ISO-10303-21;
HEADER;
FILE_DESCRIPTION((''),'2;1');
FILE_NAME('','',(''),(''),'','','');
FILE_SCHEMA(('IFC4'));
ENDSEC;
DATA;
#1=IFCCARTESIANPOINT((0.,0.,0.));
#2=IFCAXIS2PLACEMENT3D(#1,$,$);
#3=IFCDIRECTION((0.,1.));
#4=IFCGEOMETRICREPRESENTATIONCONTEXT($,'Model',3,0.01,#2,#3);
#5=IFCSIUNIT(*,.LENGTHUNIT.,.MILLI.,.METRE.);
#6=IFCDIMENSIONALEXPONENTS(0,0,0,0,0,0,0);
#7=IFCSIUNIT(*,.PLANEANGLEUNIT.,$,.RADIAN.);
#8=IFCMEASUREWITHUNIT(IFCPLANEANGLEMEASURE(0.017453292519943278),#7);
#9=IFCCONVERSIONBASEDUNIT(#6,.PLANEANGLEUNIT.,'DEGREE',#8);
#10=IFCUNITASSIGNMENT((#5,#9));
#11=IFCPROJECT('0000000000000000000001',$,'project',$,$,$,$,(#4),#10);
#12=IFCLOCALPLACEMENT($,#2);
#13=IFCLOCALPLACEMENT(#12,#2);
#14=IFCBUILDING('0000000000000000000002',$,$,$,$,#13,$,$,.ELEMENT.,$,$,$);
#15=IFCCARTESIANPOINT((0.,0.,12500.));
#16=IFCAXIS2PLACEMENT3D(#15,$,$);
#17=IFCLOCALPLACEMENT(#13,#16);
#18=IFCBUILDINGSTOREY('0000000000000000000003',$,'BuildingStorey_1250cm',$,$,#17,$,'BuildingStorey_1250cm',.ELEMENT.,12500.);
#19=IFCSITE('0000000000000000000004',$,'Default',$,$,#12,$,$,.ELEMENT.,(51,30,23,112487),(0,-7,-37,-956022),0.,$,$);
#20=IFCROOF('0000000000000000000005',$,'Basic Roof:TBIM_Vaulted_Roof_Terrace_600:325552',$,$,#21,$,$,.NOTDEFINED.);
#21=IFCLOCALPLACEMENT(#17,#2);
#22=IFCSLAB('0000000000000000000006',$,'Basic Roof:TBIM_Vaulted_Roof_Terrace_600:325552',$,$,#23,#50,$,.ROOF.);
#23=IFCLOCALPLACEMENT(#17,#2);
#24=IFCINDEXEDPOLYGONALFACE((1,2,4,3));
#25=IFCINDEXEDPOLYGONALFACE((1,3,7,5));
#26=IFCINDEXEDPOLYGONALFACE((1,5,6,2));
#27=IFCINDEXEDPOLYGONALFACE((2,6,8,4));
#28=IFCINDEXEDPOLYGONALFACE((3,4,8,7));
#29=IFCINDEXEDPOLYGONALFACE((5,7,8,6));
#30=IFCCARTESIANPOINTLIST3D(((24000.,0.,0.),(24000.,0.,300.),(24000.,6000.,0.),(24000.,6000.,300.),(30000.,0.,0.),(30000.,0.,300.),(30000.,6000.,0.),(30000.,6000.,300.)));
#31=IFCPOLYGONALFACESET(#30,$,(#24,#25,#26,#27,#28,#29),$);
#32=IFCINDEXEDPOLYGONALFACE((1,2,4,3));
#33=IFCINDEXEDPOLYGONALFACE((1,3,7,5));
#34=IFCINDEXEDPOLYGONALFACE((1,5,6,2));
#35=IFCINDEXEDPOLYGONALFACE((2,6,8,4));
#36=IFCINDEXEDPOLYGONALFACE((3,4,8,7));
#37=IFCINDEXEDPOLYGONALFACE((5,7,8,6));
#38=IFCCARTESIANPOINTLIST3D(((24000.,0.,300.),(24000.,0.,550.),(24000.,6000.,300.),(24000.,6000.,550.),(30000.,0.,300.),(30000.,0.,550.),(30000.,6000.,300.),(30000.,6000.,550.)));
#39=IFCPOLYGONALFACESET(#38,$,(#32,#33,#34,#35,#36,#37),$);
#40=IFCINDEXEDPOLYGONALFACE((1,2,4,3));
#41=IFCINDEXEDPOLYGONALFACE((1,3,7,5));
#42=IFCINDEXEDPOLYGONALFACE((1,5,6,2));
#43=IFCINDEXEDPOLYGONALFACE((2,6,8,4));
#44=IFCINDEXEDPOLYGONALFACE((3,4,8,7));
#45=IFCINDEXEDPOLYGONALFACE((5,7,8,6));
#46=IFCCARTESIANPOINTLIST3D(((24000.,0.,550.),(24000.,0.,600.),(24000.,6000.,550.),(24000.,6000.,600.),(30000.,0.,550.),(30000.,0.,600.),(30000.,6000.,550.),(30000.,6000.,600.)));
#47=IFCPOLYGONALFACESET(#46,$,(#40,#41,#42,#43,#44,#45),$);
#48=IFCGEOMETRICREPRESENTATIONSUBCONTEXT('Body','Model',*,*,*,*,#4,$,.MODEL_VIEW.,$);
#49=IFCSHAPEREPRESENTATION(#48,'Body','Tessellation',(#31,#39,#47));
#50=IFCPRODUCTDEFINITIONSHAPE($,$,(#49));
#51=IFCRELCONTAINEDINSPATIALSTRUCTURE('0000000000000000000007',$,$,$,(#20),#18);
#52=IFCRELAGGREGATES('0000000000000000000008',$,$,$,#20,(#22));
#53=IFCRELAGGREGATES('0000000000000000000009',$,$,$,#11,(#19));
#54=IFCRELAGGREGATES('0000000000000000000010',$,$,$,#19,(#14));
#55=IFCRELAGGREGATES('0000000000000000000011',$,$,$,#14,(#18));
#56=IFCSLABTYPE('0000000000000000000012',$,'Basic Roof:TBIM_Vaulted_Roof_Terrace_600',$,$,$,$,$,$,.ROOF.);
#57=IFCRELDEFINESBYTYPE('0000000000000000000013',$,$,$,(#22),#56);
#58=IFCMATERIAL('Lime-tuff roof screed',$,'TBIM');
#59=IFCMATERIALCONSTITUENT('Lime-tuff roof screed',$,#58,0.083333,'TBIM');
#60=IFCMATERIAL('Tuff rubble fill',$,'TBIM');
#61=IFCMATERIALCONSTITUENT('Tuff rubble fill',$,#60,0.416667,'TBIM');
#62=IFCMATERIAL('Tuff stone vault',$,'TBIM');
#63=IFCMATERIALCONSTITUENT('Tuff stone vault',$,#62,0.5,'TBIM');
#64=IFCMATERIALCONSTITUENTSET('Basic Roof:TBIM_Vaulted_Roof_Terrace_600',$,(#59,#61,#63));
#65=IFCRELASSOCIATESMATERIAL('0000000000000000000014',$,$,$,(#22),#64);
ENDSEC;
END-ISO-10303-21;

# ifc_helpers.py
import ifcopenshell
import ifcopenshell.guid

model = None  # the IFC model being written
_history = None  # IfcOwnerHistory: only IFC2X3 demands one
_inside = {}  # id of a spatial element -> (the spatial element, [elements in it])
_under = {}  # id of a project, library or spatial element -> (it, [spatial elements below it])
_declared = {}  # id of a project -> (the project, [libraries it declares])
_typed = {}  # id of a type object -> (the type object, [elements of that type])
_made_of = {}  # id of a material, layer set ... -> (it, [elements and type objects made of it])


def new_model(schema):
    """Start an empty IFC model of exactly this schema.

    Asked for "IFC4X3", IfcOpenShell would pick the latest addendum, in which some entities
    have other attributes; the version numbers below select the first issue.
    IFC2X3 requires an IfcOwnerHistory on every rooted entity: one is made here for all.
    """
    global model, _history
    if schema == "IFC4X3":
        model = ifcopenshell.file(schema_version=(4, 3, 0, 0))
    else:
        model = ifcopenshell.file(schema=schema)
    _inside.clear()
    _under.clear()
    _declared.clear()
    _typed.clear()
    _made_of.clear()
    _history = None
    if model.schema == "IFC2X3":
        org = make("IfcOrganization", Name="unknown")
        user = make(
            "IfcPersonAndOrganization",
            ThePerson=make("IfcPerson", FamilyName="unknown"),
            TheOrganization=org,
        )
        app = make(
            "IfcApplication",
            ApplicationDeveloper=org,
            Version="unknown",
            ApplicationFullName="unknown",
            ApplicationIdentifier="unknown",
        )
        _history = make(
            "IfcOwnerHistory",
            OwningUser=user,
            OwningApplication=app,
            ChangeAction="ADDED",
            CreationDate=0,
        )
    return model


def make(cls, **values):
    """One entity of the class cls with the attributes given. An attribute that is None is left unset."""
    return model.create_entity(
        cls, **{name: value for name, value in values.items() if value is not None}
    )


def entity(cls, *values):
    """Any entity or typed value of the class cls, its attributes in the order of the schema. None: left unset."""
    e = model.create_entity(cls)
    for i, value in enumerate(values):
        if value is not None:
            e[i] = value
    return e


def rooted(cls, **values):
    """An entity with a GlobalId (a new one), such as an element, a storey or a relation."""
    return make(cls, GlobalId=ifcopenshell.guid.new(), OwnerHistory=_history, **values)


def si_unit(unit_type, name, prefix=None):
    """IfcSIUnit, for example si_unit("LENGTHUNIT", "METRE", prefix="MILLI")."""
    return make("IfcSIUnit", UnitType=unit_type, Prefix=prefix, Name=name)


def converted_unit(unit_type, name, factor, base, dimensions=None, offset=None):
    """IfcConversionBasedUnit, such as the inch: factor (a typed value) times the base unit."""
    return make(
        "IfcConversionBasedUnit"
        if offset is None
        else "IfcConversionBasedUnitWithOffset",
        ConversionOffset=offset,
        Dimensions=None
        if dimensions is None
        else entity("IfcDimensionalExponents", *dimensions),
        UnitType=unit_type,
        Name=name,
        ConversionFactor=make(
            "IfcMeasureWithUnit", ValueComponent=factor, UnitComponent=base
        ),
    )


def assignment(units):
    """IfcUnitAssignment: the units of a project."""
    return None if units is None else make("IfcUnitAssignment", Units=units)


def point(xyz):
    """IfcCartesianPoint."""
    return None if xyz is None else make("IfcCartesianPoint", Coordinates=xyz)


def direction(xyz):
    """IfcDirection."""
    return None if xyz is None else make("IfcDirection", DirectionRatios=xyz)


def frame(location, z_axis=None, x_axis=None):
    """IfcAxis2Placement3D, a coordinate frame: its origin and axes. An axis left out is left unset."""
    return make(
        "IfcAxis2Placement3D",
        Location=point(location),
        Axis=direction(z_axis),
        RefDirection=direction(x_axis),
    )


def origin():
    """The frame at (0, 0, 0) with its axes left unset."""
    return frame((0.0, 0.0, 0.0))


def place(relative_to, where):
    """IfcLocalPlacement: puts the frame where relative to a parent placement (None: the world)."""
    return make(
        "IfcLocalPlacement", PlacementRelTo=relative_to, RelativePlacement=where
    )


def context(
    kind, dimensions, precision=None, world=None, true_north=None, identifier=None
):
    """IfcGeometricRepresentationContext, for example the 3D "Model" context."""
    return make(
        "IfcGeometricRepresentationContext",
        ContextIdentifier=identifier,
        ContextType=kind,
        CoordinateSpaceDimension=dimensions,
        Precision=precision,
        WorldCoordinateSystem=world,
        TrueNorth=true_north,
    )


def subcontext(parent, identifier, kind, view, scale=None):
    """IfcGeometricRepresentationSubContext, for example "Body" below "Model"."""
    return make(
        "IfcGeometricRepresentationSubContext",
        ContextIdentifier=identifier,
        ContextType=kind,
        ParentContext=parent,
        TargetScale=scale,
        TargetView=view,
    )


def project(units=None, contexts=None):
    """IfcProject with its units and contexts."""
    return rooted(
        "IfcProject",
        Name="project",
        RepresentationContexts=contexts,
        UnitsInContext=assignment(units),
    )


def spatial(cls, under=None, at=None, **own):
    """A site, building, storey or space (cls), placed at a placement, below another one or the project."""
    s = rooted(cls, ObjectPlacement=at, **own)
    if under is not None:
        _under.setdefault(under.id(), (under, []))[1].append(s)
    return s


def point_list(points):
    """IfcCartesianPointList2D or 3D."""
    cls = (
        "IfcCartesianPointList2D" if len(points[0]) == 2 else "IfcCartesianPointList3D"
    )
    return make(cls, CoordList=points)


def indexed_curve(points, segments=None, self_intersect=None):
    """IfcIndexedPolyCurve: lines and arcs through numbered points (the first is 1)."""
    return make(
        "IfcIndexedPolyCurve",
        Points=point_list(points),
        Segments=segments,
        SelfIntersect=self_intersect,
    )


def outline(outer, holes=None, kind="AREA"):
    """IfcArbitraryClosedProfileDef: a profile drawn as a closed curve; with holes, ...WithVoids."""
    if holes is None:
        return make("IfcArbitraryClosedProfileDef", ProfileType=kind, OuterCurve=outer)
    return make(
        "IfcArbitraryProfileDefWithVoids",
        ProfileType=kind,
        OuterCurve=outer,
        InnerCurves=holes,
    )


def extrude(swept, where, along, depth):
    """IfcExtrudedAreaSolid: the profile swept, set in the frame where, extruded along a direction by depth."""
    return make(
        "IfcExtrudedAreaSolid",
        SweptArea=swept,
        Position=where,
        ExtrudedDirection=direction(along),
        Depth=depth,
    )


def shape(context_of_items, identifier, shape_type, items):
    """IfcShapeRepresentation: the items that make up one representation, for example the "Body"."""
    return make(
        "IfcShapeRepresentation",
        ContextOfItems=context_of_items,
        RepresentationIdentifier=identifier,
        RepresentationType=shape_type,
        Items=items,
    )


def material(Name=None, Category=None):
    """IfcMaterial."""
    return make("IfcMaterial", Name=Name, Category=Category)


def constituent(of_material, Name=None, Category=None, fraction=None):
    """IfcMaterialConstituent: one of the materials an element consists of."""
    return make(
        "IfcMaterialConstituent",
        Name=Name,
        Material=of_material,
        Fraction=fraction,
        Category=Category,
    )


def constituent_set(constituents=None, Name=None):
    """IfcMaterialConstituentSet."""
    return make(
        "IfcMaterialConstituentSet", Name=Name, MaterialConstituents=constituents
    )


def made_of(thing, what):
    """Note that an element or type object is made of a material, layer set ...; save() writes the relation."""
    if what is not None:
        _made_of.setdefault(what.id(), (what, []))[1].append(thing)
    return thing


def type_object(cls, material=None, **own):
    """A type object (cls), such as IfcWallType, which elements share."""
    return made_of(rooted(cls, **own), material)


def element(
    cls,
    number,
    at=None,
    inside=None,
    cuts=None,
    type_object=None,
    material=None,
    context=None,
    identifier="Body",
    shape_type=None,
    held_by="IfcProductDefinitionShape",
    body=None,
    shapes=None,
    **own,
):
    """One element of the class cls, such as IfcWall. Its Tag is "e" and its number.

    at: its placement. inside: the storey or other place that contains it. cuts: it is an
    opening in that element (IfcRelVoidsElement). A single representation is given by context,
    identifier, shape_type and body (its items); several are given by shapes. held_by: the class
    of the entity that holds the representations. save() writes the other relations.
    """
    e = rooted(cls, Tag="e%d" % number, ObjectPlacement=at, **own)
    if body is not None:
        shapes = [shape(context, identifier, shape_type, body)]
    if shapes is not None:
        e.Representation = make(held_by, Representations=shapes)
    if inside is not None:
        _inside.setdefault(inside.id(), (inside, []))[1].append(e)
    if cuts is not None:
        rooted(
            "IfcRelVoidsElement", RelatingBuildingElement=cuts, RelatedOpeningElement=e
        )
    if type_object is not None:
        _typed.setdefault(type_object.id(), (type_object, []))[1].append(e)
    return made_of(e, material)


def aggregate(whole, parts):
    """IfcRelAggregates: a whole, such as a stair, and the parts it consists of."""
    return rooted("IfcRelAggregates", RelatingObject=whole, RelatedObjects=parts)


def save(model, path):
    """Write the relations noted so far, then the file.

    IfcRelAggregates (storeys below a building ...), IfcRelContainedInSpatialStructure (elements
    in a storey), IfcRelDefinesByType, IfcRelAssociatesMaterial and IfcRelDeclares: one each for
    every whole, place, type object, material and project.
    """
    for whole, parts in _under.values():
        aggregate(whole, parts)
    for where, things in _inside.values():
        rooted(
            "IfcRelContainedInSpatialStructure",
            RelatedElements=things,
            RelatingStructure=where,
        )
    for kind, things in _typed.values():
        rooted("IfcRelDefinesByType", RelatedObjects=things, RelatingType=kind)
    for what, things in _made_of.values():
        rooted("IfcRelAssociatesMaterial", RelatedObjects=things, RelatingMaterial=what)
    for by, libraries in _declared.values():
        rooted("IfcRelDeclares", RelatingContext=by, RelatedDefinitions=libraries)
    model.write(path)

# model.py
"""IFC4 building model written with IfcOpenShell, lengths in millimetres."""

from ifc_helpers import new_model, entity, si_unit, converted_unit, direction, frame, origin, place, context, subcontext, project, spatial, indexed_curve, outline, extrude, material, constituent, constituent_set, type_object, element, aggregate, save


model = new_model("IFC4")

# Units and contexts
model_context = context("Model", 3, precision=0.01, world=origin(), true_north=direction((0.0, 1.0)))
body_context = subcontext(model_context, "Body", "Model", "MODEL_VIEW")
ifc_project = project(units=[si_unit("LENGTHUNIT", "METRE", prefix="MILLI"), converted_unit("PLANEANGLEUNIT", "DEGREE", entity("IfcPlaneAngleMeasure", 0.017453292519943278), si_unit("PLANEANGLEUNIT", "RADIAN"), dimensions=[0, 0, 0, 0, 0, 0, 0])], contexts=[model_context])

# Site, building, storey
site_placement = place(None, origin())
site = spatial("IfcSite", under=ifc_project, at=site_placement, Name="Default", CompositionType="ELEMENT", RefLatitude=(51, 30, 23, 112487), RefLongitude=(0, -7, -37, -956022), RefElevation=0.0)
building_placement = place(site_placement, origin())
building = spatial("IfcBuilding", under=site, at=building_placement, CompositionType="ELEMENT")
storey_placement = place(building_placement, frame((0.0, 0.0, 12500.0)))
storey = spatial("IfcBuildingStorey", under=building, at=storey_placement, Name="BuildingStorey_1250cm", LongName="BuildingStorey_1250cm", CompositionType="ELEMENT", Elevation=12500.0)

# Roof, slab
roof_placement = place(storey_placement, frame((24000.0, 0.0, 0.0)))
roof = element("IfcRoof", 1, at=roof_placement, inside=storey, Name="Basic Roof:TBIM_Vaulted_Roof_Terrace_600:325552", PredefinedType="NOTDEFINED")
ifc_material_1 = material(Name="Lime-tuff roof screed", Category="TBIM")
ifc_constituent_1 = constituent(ifc_material_1, Name="Lime-tuff roof screed", Category="TBIM", fraction=0.083333)
ifc_material_2 = material(Name="Tuff rubble fill", Category="TBIM")
ifc_constituent_2 = constituent(ifc_material_2, Name="Tuff rubble fill", Category="TBIM", fraction=0.416667)
ifc_material_3 = material(Name="Tuff stone vault", Category="TBIM")
ifc_constituent_3 = constituent(ifc_material_3, Name="Tuff stone vault", Category="TBIM", fraction=0.5)
ifc_constituent_set = constituent_set(constituents=[ifc_constituent_1, ifc_constituent_2, ifc_constituent_3], Name="Basic Roof:TBIM_Vaulted_Roof_Terrace_600")
slab_type = type_object("IfcSlabType", Name="Basic Roof:TBIM_Vaulted_Roof_Terrace_600", PredefinedType="ROOF")
slab_placement = place(roof_placement, origin())
slab = element("IfcSlab", 2, at=slab_placement, type_object=slab_type, material=ifc_constituent_set, Name="Basic Roof:TBIM_Vaulted_Roof_Terrace_600:325552", PredefinedType="ROOF", context=body_context, shape_type="SweptSolid", body=[
    extrude(outline(indexed_curve([(-3000.0, 3000.0), (-3000.0, -3000.0), (3000.0, -3000.0), (3000.0, 3000.0), (-3000.0, 3000.0)], self_intersect=False)), frame((3000.0, 3000.0, 0.0)), (0.0, 0.0, 1.0), 300.0),
    extrude(outline(indexed_curve([(-3000.0, 3000.0), (-3000.0, -3000.0), (3000.0, -3000.0), (3000.0, 3000.0), (-3000.0, 3000.0)], self_intersect=False)), frame((3000.0, 3000.0, 300.0)), (0.0, 0.0, 1.0), 250.0),
    extrude(outline(indexed_curve([(-3000.0, 3000.0), (-3000.0, -3000.0), (3000.0, -3000.0), (3000.0, 3000.0), (-3000.0, 3000.0)], self_intersect=False)), frame((3000.0, 3000.0, 550.0)), (0.0, 0.0, 1.0), 50.0),
])
aggregate(roof, [slab])

save(model, "model.ifc")
